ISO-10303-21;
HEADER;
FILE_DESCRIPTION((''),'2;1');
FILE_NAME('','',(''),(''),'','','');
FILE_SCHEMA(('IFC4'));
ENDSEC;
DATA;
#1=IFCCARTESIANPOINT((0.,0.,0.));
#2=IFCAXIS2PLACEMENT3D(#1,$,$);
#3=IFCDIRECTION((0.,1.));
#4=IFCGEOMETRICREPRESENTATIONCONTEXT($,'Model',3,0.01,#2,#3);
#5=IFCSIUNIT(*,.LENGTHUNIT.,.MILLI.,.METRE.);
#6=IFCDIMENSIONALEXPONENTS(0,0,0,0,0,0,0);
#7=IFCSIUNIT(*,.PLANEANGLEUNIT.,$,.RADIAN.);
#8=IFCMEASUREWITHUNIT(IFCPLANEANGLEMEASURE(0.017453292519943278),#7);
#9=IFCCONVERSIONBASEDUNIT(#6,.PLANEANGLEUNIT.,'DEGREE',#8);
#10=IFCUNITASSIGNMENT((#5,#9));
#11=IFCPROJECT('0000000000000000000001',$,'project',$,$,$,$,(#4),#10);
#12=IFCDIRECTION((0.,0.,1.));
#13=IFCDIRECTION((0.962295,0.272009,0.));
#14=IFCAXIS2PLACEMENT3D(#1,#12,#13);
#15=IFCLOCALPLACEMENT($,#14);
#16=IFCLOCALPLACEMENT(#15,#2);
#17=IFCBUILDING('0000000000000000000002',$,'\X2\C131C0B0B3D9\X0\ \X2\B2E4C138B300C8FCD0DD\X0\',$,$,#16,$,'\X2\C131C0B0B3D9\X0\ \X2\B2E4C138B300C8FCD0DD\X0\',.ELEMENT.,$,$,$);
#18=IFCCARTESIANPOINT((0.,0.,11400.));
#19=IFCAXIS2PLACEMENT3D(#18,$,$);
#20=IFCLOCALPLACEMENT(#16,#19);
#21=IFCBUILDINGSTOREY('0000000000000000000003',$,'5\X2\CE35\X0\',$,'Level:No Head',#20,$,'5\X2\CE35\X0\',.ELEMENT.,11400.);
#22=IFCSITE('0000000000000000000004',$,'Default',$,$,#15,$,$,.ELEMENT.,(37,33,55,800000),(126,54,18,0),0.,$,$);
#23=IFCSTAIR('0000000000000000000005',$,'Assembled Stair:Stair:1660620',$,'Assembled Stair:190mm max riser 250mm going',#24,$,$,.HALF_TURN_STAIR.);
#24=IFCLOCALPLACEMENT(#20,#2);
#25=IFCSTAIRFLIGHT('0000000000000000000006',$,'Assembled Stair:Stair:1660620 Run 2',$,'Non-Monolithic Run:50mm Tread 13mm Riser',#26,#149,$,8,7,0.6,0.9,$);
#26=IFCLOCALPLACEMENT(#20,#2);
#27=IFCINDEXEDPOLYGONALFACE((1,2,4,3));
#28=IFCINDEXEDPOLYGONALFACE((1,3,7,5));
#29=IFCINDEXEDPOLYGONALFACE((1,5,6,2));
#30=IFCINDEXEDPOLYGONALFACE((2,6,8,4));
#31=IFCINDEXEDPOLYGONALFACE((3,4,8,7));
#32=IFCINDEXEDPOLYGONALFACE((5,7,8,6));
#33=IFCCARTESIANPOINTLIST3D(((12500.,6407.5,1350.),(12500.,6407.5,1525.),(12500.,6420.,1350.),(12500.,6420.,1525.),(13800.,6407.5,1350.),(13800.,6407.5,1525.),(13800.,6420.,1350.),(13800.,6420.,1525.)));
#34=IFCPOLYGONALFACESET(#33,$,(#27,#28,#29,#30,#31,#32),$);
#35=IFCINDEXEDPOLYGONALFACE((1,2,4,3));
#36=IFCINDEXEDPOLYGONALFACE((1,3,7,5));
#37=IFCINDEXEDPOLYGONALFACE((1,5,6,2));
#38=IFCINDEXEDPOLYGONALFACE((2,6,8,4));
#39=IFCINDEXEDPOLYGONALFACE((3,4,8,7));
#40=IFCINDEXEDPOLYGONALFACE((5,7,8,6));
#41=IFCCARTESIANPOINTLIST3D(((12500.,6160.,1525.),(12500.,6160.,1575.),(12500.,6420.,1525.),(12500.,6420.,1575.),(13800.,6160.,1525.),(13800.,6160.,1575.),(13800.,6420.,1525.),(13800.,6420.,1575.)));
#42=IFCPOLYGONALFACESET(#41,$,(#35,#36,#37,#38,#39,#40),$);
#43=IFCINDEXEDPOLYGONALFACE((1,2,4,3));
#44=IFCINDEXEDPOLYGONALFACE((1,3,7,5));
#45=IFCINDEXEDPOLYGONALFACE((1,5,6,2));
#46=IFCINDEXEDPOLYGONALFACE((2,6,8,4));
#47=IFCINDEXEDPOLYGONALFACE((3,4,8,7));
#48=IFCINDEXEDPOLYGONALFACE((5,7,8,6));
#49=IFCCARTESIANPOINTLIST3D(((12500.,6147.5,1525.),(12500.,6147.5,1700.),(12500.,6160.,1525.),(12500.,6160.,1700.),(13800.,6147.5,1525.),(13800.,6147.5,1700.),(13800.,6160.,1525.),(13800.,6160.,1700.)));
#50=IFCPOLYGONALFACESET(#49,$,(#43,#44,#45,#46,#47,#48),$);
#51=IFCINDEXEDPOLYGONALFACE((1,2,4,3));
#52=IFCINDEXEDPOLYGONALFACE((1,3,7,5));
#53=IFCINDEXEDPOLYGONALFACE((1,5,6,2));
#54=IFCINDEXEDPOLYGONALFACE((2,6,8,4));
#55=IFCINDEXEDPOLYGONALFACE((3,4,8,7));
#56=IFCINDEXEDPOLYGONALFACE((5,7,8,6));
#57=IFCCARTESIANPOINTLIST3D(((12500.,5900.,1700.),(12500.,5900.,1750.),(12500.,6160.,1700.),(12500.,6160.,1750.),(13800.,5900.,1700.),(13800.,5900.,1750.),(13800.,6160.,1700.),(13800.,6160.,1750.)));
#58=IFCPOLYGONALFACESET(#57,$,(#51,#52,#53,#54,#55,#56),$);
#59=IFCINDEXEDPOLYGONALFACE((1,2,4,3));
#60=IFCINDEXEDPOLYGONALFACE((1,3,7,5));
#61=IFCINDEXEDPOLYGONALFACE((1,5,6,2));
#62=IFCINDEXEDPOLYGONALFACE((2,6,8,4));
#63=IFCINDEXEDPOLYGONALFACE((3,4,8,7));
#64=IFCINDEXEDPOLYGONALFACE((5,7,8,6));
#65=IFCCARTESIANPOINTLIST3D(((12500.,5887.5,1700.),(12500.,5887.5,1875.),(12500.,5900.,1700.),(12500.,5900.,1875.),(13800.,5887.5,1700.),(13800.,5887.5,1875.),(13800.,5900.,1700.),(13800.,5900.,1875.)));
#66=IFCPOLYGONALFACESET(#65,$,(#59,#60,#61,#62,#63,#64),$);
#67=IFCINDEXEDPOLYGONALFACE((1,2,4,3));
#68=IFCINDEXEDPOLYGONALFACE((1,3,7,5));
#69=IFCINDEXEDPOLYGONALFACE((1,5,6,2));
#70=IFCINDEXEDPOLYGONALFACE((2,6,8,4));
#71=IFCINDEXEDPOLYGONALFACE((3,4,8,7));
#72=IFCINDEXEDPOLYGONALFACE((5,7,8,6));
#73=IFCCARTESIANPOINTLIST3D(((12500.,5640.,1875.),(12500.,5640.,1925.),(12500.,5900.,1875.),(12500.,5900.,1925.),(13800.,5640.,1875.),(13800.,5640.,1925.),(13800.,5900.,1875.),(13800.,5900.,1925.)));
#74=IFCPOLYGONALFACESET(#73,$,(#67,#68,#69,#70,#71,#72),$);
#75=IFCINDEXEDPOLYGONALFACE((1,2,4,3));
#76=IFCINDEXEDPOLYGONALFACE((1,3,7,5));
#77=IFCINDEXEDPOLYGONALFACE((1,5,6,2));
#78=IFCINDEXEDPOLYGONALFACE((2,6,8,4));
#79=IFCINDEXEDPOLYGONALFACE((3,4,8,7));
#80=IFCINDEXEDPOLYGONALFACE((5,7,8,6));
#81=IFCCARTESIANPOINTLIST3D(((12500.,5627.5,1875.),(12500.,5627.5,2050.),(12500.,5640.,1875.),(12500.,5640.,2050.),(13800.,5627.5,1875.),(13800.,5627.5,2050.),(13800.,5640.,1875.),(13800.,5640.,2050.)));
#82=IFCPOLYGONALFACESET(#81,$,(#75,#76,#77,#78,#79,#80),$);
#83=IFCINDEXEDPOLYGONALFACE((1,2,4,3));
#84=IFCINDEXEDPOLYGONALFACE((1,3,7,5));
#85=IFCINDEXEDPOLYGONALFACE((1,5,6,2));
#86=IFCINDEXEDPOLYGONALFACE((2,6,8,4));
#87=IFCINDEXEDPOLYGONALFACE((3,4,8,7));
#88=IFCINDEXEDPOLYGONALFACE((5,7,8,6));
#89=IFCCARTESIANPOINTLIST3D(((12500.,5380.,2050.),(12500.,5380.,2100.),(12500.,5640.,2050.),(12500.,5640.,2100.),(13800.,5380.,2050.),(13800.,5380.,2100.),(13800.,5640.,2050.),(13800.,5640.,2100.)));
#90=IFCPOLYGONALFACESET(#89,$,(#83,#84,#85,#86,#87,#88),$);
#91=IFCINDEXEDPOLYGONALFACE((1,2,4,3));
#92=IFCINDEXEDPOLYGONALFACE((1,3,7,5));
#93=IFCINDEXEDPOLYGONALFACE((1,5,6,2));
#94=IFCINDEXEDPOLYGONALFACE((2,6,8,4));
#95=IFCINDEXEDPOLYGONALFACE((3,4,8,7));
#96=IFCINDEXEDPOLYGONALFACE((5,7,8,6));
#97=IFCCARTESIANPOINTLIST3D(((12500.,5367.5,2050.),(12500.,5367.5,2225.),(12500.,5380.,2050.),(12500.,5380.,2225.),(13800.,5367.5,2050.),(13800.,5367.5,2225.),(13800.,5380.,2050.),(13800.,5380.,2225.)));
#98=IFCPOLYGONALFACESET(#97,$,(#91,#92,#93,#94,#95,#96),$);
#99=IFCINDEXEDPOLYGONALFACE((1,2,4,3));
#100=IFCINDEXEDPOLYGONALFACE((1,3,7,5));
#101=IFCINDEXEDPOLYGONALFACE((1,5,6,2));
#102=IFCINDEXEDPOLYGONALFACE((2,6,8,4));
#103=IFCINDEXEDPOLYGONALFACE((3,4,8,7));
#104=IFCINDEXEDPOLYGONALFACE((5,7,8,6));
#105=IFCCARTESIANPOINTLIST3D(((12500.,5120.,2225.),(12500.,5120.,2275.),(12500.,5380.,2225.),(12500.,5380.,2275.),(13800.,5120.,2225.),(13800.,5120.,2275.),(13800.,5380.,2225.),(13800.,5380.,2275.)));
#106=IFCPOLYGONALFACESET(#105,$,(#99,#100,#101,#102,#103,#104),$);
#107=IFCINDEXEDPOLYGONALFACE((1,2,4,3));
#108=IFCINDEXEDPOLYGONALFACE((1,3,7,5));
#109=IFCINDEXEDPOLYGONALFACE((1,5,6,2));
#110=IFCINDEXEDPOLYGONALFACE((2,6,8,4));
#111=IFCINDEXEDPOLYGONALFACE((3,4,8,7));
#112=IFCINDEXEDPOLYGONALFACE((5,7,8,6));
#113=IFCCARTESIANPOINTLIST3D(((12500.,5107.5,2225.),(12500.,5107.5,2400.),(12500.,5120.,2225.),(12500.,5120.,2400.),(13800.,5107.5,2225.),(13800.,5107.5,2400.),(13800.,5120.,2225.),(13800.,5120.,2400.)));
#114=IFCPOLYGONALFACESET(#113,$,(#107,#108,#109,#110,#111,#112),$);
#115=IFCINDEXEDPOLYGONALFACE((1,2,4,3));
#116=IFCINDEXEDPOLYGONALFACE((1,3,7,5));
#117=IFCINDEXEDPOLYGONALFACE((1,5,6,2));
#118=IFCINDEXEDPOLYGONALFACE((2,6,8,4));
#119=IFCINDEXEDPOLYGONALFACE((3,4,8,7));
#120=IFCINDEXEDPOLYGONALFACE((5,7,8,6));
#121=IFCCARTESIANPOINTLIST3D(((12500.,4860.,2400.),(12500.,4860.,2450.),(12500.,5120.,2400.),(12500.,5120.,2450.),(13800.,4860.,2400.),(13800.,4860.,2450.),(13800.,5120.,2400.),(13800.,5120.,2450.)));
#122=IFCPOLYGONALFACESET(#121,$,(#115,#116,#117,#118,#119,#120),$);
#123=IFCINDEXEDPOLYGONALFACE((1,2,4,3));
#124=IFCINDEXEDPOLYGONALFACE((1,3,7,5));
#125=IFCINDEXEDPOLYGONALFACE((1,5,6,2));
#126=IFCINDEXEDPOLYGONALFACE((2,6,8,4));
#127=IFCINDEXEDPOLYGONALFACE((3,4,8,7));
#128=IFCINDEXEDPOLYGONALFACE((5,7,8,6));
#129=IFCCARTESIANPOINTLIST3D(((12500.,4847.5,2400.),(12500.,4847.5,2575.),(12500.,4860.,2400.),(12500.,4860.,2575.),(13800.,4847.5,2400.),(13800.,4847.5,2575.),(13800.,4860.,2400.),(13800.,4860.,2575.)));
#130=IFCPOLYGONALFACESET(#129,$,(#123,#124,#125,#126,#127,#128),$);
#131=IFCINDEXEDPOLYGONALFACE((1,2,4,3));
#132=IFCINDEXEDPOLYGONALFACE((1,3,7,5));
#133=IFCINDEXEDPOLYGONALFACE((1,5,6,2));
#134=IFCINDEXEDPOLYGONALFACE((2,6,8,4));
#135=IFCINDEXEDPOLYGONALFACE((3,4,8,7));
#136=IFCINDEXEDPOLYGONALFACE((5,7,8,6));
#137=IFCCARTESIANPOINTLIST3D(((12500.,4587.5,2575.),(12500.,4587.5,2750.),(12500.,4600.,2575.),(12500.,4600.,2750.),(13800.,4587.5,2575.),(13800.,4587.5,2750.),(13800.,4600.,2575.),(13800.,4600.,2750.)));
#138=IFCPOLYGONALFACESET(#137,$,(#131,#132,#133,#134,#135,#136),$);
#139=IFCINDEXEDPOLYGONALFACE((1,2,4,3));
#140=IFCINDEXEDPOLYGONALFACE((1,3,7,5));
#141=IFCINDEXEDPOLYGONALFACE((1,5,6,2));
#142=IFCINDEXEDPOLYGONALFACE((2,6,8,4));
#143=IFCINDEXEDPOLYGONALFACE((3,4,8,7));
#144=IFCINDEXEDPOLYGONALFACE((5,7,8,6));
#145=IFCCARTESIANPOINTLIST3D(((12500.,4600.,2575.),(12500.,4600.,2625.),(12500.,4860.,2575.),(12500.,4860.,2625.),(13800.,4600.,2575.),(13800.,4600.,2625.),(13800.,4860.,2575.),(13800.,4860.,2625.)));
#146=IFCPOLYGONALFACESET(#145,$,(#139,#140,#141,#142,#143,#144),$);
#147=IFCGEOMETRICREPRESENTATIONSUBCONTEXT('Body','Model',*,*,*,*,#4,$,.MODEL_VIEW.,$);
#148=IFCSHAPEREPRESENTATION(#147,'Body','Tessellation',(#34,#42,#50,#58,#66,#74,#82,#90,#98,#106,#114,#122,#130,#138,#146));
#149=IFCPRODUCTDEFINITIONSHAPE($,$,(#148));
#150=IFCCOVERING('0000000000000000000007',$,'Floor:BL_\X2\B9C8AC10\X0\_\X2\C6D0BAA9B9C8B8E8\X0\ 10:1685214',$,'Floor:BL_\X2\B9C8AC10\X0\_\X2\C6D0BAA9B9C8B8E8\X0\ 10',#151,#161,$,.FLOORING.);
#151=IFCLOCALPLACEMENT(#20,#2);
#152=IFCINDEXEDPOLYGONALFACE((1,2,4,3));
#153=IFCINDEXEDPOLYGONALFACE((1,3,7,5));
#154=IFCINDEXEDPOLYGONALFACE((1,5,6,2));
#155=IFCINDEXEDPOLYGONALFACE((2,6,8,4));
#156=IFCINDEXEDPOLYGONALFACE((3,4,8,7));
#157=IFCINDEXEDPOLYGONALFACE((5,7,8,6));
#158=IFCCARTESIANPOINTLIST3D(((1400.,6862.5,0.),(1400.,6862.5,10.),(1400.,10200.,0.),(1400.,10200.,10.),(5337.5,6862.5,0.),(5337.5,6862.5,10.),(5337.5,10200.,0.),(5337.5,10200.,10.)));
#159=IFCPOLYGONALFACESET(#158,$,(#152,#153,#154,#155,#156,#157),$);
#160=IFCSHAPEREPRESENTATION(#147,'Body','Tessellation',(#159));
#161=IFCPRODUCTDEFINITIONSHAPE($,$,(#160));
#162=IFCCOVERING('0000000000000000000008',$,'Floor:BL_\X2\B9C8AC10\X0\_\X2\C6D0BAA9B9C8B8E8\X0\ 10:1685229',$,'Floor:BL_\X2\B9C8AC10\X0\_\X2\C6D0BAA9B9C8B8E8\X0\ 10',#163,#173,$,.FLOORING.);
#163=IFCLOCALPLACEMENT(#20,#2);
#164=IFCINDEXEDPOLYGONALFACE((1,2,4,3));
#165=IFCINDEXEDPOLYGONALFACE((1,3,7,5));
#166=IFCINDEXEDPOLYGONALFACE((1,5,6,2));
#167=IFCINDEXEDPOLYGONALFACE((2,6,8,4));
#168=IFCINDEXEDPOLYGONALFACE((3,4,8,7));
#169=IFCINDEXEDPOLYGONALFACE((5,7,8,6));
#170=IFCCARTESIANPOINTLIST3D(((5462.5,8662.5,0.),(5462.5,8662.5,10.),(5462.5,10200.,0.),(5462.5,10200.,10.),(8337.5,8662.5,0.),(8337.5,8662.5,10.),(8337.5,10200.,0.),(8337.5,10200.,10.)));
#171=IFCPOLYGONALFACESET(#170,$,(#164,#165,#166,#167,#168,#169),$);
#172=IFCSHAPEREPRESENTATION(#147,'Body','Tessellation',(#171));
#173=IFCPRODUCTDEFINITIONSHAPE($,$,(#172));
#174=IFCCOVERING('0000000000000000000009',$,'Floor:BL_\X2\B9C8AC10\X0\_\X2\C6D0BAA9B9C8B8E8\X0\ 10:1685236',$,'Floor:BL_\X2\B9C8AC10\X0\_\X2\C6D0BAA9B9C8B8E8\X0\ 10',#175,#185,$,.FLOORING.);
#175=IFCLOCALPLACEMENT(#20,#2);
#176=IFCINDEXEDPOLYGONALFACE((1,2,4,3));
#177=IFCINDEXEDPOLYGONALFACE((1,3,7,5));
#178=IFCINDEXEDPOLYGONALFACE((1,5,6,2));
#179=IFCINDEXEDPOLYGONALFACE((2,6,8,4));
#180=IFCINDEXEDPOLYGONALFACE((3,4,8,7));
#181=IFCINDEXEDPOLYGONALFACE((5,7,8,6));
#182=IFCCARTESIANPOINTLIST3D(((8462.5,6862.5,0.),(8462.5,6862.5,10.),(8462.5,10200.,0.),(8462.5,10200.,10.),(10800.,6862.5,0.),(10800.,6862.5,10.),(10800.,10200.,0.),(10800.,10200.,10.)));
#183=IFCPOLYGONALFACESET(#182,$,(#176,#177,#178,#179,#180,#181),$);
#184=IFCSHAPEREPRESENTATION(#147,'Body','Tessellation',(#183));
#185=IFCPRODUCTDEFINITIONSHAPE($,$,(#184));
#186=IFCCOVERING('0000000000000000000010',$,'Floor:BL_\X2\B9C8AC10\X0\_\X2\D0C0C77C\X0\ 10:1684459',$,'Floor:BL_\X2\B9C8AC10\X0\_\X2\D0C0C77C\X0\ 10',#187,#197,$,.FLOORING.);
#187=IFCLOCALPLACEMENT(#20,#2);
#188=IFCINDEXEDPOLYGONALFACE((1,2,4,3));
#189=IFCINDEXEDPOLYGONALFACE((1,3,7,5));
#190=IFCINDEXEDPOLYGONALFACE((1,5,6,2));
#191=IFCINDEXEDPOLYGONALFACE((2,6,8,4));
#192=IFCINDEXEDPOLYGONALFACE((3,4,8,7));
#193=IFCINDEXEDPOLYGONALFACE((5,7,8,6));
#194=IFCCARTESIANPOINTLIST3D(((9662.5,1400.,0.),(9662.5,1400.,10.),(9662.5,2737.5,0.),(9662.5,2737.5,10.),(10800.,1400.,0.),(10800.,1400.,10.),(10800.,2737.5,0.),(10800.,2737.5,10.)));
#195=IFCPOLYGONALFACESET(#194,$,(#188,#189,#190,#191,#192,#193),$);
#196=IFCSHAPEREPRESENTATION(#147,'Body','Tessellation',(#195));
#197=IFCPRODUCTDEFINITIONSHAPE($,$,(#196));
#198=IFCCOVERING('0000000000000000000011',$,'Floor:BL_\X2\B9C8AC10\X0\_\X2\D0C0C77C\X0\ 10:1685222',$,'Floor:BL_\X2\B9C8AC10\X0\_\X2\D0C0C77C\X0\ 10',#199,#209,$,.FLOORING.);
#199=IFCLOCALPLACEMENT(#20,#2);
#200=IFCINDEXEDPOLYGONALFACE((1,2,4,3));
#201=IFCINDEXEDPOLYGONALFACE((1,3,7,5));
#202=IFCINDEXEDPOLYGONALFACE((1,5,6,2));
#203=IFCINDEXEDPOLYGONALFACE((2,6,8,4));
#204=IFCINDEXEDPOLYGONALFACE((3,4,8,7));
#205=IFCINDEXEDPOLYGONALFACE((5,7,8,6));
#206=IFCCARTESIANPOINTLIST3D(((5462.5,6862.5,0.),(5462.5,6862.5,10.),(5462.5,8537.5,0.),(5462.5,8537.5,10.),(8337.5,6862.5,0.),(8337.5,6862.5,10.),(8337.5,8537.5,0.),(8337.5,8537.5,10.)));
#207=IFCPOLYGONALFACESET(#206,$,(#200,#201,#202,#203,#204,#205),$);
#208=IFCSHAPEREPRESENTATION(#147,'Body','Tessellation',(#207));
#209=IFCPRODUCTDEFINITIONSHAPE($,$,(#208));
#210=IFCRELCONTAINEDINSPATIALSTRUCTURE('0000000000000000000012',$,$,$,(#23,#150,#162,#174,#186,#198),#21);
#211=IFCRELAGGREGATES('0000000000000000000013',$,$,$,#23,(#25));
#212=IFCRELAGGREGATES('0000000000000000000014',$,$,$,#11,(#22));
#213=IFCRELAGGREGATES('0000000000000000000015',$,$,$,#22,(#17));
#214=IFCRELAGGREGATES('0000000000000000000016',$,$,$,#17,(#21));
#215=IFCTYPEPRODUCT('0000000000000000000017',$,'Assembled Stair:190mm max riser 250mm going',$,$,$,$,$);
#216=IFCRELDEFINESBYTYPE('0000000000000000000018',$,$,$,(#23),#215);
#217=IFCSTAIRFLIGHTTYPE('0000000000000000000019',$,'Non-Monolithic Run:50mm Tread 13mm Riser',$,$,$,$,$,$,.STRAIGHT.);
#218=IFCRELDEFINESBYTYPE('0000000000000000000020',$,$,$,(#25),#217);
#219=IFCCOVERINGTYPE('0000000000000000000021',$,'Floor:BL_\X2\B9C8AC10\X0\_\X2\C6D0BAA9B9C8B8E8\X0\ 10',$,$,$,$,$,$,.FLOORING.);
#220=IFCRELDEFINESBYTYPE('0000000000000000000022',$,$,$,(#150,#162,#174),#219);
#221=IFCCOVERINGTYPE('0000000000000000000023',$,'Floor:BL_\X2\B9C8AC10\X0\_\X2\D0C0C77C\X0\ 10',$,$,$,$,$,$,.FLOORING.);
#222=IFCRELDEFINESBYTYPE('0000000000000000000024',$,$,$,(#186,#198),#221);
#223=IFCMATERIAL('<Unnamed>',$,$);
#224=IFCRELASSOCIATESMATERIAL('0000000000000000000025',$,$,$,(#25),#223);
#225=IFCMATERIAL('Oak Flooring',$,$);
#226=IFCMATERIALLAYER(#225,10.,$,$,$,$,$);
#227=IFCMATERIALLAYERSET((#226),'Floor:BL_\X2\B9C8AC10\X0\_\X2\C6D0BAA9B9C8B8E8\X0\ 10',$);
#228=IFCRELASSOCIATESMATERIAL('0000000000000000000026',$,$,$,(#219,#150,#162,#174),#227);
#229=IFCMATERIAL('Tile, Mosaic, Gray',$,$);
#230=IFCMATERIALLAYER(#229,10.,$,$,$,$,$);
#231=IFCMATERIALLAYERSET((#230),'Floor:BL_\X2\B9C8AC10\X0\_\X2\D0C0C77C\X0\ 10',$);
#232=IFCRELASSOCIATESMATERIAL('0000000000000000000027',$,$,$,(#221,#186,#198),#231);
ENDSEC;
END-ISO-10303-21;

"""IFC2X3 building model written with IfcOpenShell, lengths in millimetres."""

from ifc_helpers import new_model, entity, si_unit, converted_unit, direction, frame, frame_2d, origin, origin_2d_with_axis, place, context, subcontext, project, spatial, rectangle, extrude, material, layer, layer_set, layer_usage, type_object, element, aggregate, save


model = new_model("IFC2X3")

# Units and contexts
model_context = context("Model", 3, precision=0.01, world=origin(), true_north=direction((0.0, 1.0)))
body_context = subcontext(model_context, "Body", "Model", "MODEL_VIEW")
ifc_project = project(units=[si_unit("LENGTHUNIT", "METRE", prefix="MILLI"), converted_unit("PLANEANGLEUNIT", "DEGREE", entity("IfcPlaneAngleMeasure", 0.017453292519943278), si_unit("PLANEANGLEUNIT", "RADIAN"), dimensions=[0, 0, 0, 0, 0, 0, 0])], contexts=[model_context])

# Site, building, storey
site_placement = place(None, frame((0.0, 0.0, 0.0), z_axis=(0.0, 0.0, 1.0), x_axis=(0.962295, 0.272009, 0.0)))
site = spatial("IfcSite", under=ifc_project, at=site_placement, Name="Default", CompositionType="ELEMENT", RefLatitude=(37, 33, 55, 800000), RefLongitude=(126, 54, 18, 0), RefElevation=0.0)
building_placement = place(site_placement, origin())
building = spatial("IfcBuilding", under=site, at=building_placement, Name="성산동 다세대주택", LongName="성산동 다세대주택", CompositionType="ELEMENT")
storey_placement = place(building_placement, frame((0.0, 0.0, 11400.0)))
storey = spatial("IfcBuildingStorey", under=building, at=storey_placement, Name="5층", ObjectType="Level:No Head", LongName="5층", CompositionType="ELEMENT", Elevation=11400.0)

# Stair
type_product = type_object("IfcTypeProduct", Name="Assembled Stair:190mm max riser 250mm going")
stair_placement = place(storey_placement, origin())
stair = element("IfcStair", 1, at=stair_placement, inside=storey, type_object=type_product, Name="Assembled Stair:Stair:1660620", ObjectType="Assembled Stair:190mm max riser 250mm going", ShapeType="HALF_TURN_STAIR")
ifc_material_1 = material(Name="<Unnamed>")

# Stair flight
stair_flight_type = type_object("IfcStairFlightType", Name="Non-Monolithic Run:50mm Tread 13mm Riser", PredefinedType="STRAIGHT")
stair_flight_1_placement = place(stair_placement, origin())
stair_flight_1 = element("IfcStairFlight", 2, at=stair_flight_1_placement, type_object=stair_flight_type, material=ifc_material_1, Name="Assembled Stair:Stair:1660620 Run 2", ObjectType="Non-Monolithic Run:50mm Tread 13mm Riser", NumberOfRiser=8, NumberOfTreads=7, RiserHeight=0.6, TreadLength=0.9, context=body_context, shape_type="SweptSolid", body=[
    extrude(rectangle(XDim=1300.0, YDim=12.5, at=frame_2d((0.0, 0.0), x_axis=(1.0, 0.0))), frame((13150.0, 6413.7, 1350.0)), (0.0, 0.0, 1.0), 175.0),
    extrude(rectangle(XDim=260.0, YDim=1300.0, at=frame_2d((0.0, 0.0), x_axis=(1.0, 0.0))), frame((13150.0, 6290.0, 1525.0), z_axis=(0.0, 0.0, 1.0), x_axis=(0.0, 1.0, 0.0)), (0.0, 0.0, 1.0), 50.0),
    extrude(rectangle(XDim=1300.0, YDim=12.5, at=frame_2d((0.0, 0.0), x_axis=(1.0, 0.0))), frame((13150.0, 6153.7, 1525.0)), (0.0, 0.0, 1.0), 175.0),
    extrude(rectangle(XDim=260.0, YDim=1300.0, at=origin_2d_with_axis()), frame((13150.0, 6030.0, 1700.0), z_axis=(0.0, 0.0, 1.0), x_axis=(0.0, 1.0, 0.0)), (0.0, 0.0, 1.0), 50.0),
    extrude(rectangle(XDim=1300.0, YDim=12.5, at=frame_2d((0.0, 0.0), x_axis=(1.0, 0.0))), frame((13150.0, 5893.7, 1700.0)), (0.0, 0.0, 1.0), 175.0),
    extrude(rectangle(XDim=260.0, YDim=1300.0, at=origin_2d_with_axis()), frame((13150.0, 5770.0, 1875.0), z_axis=(0.0, 0.0, 1.0), x_axis=(0.0, 1.0, 0.0)), (0.0, 0.0, 1.0), 50.0),
    extrude(rectangle(XDim=1300.0, YDim=12.5, at=frame_2d((0.0, 0.0), x_axis=(1.0, 0.0))), frame((13150.0, 5633.7, 1875.0)), (0.0, 0.0, 1.0), 175.0),
    extrude(rectangle(XDim=260.0, YDim=1300.0, at=origin_2d_with_axis()), frame((13150.0, 5510.0, 2050.0), z_axis=(0.0, 0.0, 1.0), x_axis=(0.0, 1.0, 0.0)), (0.0, 0.0, 1.0), 50.0),
    extrude(rectangle(XDim=1300.0, YDim=12.5, at=frame_2d((0.0, 0.0), x_axis=(1.0, 0.0))), frame((13150.0, 5373.7, 2050.0)), (0.0, 0.0, 1.0), 175.0),
    extrude(rectangle(XDim=260.0, YDim=1300.0, at=origin_2d_with_axis()), frame((13150.0, 5250.0, 2225.0), z_axis=(0.0, 0.0, 1.0), x_axis=(0.0, 1.0, 0.0)), (0.0, 0.0, 1.0), 50.0),
    extrude(rectangle(XDim=1300.0, YDim=12.5, at=frame_2d((0.0, 0.0), x_axis=(1.0, 0.0))), frame((13150.0, 5113.7, 2225.0)), (0.0, 0.0, 1.0), 175.0),
    extrude(rectangle(XDim=260.0, YDim=1300.0, at=origin_2d_with_axis()), frame((13150.0, 4990.0, 2400.0), z_axis=(0.0, 0.0, 1.0), x_axis=(0.0, 1.0, 0.0)), (0.0, 0.0, 1.0), 50.0),
    extrude(rectangle(XDim=1300.0, YDim=12.5, at=frame_2d((0.0, 0.0), x_axis=(1.0, 0.0))), frame((13150.0, 4853.7, 2400.0)), (0.0, 0.0, 1.0), 175.0),
    extrude(rectangle(XDim=1300.0, YDim=12.5, at=frame_2d((0.0, 0.0), x_axis=(1.0, 0.0))), frame((13150.0, 4593.8, 2575.0)), (0.0, 0.0, 1.0), 175.0),
    extrude(rectangle(XDim=260.0, YDim=1300.0, at=origin_2d_with_axis()), frame((13150.0, 4730.0, 2575.0), z_axis=(0.0, 0.0, 1.0), x_axis=(0.0, 1.0, 0.0)), (0.0, 0.0, 1.0), 50.0),
])
aggregate(stair, [stair_flight_1])

# Coverings
ifc_material_2 = material(Name="Oak Flooring")
ifc_layer_1 = layer(ifc_material_2, 10.0)
ifc_layer_set_1 = layer_set([ifc_layer_1], Name="Floor:BL_마감_원목마루 10")
covering_type_1 = type_object("IfcCoveringType", Name="Floor:BL_마감_원목마루 10", PredefinedType="FLOORING", material=ifc_layer_set_1)
ifc_layer_usage_1 = layer_usage(ifc_layer_set_1, "AXIS3", "POSITIVE", 0.0)
covering_1_placement = place(storey_placement, origin())
element("IfcCovering", 3, at=covering_1_placement, inside=storey, type_object=covering_type_1, material=ifc_layer_usage_1, Name="Floor:BL_마감_원목마루 10:1685214", ObjectType="Floor:BL_마감_원목마루 10", PredefinedType="FLOORING", context=body_context, shape_type="SweptSolid", body=[
    extrude(rectangle(XDim=3337.5, YDim=3937.5, at=frame_2d((0.0, 0.0), x_axis=(1.0, 0.0))), frame((3368.8, 8531.3, 10.0), z_axis=(0.0, 0.0, -1.0), x_axis=(0.0, 1.0, 0.0)), (0.0, 0.0, 1.0), 10.0),
])
ifc_layer_usage_2 = layer_usage(ifc_layer_set_1, "AXIS3", "POSITIVE", 0.0)
covering_2_placement = place(storey_placement, origin())
element("IfcCovering", 4, at=covering_2_placement, inside=storey, type_object=covering_type_1, material=ifc_layer_usage_2, Name="Floor:BL_마감_원목마루 10:1685229", ObjectType="Floor:BL_마감_원목마루 10", PredefinedType="FLOORING", context=body_context, shape_type="SweptSolid", body=[
    extrude(rectangle(XDim=1537.5, YDim=2875.0, at=frame_2d((0.0, 0.0), x_axis=(1.0, 0.0))), frame((6900.0, 9431.2, 10.0), z_axis=(0.0, 0.0, -1.0), x_axis=(0.0, 1.0, 0.0)), (0.0, 0.0, 1.0), 10.0),
])
ifc_layer_usage_3 = layer_usage(ifc_layer_set_1, "AXIS3", "POSITIVE", 0.0)
covering_3_placement = place(storey_placement, origin())
element("IfcCovering", 5, at=covering_3_placement, inside=storey, type_object=covering_type_1, material=ifc_layer_usage_3, Name="Floor:BL_마감_원목마루 10:1685236", ObjectType="Floor:BL_마감_원목마루 10", PredefinedType="FLOORING", context=body_context, shape_type="SweptSolid", body=[
    extrude(rectangle(XDim=2337.5, YDim=3337.5, at=frame_2d((0.0, 0.0), x_axis=(1.0, 0.0))), frame((9631.2, 8531.2, 10.0), z_axis=(0.0, 0.0, -1.0), x_axis=(1.0, 0.0, 0.0)), (0.0, 0.0, 1.0), 10.0),
])
ifc_material_3 = material(Name="Tile, Mosaic, Gray")
ifc_layer_2 = layer(ifc_material_3, 10.0)
ifc_layer_set_2 = layer_set([ifc_layer_2], Name="Floor:BL_마감_타일 10")
ifc_layer_usage_4 = layer_usage(ifc_layer_set_2, "AXIS3", "POSITIVE", 0.0)
covering_type_2 = type_object("IfcCoveringType", Name="Floor:BL_마감_타일 10", PredefinedType="FLOORING", material=ifc_layer_set_2)
covering_4_placement = place(storey_placement, origin())
element("IfcCovering", 6, at=covering_4_placement, inside=storey, type_object=covering_type_2, material=ifc_layer_usage_4, Name="Floor:BL_마감_타일 10:1684459", ObjectType="Floor:BL_마감_타일 10", PredefinedType="FLOORING", context=body_context, shape_type="SweptSolid", body=[
    extrude(rectangle(XDim=1337.5, YDim=1137.5, at=frame_2d((0.0, 0.0), x_axis=(1.0, 0.0))), frame((10231.2, 2068.8, 10.0), z_axis=(0.0, 0.0, -1.0), x_axis=(0.0, 1.0, 0.0)), (0.0, 0.0, 1.0), 10.0),
])
ifc_layer_usage_5 = layer_usage(ifc_layer_set_2, "AXIS3", "POSITIVE", 0.0)
covering_5_placement = place(storey_placement, origin())
element("IfcCovering", 7, at=covering_5_placement, inside=storey, type_object=covering_type_2, material=ifc_layer_usage_5, Name="Floor:BL_마감_타일 10:1685222", ObjectType="Floor:BL_마감_타일 10", PredefinedType="FLOORING", context=body_context, shape_type="SweptSolid", body=[
    extrude(rectangle(XDim=1675.0, YDim=2875.0, at=frame_2d((0.0, 0.0), x_axis=(1.0, 0.0))), frame((6900.0, 7700.0, 10.0), z_axis=(0.0, 0.0, -1.0), x_axis=(0.0, 1.0, 0.0)), (0.0, 0.0, 1.0), 10.0),
])

save(model, "model.ifc")
